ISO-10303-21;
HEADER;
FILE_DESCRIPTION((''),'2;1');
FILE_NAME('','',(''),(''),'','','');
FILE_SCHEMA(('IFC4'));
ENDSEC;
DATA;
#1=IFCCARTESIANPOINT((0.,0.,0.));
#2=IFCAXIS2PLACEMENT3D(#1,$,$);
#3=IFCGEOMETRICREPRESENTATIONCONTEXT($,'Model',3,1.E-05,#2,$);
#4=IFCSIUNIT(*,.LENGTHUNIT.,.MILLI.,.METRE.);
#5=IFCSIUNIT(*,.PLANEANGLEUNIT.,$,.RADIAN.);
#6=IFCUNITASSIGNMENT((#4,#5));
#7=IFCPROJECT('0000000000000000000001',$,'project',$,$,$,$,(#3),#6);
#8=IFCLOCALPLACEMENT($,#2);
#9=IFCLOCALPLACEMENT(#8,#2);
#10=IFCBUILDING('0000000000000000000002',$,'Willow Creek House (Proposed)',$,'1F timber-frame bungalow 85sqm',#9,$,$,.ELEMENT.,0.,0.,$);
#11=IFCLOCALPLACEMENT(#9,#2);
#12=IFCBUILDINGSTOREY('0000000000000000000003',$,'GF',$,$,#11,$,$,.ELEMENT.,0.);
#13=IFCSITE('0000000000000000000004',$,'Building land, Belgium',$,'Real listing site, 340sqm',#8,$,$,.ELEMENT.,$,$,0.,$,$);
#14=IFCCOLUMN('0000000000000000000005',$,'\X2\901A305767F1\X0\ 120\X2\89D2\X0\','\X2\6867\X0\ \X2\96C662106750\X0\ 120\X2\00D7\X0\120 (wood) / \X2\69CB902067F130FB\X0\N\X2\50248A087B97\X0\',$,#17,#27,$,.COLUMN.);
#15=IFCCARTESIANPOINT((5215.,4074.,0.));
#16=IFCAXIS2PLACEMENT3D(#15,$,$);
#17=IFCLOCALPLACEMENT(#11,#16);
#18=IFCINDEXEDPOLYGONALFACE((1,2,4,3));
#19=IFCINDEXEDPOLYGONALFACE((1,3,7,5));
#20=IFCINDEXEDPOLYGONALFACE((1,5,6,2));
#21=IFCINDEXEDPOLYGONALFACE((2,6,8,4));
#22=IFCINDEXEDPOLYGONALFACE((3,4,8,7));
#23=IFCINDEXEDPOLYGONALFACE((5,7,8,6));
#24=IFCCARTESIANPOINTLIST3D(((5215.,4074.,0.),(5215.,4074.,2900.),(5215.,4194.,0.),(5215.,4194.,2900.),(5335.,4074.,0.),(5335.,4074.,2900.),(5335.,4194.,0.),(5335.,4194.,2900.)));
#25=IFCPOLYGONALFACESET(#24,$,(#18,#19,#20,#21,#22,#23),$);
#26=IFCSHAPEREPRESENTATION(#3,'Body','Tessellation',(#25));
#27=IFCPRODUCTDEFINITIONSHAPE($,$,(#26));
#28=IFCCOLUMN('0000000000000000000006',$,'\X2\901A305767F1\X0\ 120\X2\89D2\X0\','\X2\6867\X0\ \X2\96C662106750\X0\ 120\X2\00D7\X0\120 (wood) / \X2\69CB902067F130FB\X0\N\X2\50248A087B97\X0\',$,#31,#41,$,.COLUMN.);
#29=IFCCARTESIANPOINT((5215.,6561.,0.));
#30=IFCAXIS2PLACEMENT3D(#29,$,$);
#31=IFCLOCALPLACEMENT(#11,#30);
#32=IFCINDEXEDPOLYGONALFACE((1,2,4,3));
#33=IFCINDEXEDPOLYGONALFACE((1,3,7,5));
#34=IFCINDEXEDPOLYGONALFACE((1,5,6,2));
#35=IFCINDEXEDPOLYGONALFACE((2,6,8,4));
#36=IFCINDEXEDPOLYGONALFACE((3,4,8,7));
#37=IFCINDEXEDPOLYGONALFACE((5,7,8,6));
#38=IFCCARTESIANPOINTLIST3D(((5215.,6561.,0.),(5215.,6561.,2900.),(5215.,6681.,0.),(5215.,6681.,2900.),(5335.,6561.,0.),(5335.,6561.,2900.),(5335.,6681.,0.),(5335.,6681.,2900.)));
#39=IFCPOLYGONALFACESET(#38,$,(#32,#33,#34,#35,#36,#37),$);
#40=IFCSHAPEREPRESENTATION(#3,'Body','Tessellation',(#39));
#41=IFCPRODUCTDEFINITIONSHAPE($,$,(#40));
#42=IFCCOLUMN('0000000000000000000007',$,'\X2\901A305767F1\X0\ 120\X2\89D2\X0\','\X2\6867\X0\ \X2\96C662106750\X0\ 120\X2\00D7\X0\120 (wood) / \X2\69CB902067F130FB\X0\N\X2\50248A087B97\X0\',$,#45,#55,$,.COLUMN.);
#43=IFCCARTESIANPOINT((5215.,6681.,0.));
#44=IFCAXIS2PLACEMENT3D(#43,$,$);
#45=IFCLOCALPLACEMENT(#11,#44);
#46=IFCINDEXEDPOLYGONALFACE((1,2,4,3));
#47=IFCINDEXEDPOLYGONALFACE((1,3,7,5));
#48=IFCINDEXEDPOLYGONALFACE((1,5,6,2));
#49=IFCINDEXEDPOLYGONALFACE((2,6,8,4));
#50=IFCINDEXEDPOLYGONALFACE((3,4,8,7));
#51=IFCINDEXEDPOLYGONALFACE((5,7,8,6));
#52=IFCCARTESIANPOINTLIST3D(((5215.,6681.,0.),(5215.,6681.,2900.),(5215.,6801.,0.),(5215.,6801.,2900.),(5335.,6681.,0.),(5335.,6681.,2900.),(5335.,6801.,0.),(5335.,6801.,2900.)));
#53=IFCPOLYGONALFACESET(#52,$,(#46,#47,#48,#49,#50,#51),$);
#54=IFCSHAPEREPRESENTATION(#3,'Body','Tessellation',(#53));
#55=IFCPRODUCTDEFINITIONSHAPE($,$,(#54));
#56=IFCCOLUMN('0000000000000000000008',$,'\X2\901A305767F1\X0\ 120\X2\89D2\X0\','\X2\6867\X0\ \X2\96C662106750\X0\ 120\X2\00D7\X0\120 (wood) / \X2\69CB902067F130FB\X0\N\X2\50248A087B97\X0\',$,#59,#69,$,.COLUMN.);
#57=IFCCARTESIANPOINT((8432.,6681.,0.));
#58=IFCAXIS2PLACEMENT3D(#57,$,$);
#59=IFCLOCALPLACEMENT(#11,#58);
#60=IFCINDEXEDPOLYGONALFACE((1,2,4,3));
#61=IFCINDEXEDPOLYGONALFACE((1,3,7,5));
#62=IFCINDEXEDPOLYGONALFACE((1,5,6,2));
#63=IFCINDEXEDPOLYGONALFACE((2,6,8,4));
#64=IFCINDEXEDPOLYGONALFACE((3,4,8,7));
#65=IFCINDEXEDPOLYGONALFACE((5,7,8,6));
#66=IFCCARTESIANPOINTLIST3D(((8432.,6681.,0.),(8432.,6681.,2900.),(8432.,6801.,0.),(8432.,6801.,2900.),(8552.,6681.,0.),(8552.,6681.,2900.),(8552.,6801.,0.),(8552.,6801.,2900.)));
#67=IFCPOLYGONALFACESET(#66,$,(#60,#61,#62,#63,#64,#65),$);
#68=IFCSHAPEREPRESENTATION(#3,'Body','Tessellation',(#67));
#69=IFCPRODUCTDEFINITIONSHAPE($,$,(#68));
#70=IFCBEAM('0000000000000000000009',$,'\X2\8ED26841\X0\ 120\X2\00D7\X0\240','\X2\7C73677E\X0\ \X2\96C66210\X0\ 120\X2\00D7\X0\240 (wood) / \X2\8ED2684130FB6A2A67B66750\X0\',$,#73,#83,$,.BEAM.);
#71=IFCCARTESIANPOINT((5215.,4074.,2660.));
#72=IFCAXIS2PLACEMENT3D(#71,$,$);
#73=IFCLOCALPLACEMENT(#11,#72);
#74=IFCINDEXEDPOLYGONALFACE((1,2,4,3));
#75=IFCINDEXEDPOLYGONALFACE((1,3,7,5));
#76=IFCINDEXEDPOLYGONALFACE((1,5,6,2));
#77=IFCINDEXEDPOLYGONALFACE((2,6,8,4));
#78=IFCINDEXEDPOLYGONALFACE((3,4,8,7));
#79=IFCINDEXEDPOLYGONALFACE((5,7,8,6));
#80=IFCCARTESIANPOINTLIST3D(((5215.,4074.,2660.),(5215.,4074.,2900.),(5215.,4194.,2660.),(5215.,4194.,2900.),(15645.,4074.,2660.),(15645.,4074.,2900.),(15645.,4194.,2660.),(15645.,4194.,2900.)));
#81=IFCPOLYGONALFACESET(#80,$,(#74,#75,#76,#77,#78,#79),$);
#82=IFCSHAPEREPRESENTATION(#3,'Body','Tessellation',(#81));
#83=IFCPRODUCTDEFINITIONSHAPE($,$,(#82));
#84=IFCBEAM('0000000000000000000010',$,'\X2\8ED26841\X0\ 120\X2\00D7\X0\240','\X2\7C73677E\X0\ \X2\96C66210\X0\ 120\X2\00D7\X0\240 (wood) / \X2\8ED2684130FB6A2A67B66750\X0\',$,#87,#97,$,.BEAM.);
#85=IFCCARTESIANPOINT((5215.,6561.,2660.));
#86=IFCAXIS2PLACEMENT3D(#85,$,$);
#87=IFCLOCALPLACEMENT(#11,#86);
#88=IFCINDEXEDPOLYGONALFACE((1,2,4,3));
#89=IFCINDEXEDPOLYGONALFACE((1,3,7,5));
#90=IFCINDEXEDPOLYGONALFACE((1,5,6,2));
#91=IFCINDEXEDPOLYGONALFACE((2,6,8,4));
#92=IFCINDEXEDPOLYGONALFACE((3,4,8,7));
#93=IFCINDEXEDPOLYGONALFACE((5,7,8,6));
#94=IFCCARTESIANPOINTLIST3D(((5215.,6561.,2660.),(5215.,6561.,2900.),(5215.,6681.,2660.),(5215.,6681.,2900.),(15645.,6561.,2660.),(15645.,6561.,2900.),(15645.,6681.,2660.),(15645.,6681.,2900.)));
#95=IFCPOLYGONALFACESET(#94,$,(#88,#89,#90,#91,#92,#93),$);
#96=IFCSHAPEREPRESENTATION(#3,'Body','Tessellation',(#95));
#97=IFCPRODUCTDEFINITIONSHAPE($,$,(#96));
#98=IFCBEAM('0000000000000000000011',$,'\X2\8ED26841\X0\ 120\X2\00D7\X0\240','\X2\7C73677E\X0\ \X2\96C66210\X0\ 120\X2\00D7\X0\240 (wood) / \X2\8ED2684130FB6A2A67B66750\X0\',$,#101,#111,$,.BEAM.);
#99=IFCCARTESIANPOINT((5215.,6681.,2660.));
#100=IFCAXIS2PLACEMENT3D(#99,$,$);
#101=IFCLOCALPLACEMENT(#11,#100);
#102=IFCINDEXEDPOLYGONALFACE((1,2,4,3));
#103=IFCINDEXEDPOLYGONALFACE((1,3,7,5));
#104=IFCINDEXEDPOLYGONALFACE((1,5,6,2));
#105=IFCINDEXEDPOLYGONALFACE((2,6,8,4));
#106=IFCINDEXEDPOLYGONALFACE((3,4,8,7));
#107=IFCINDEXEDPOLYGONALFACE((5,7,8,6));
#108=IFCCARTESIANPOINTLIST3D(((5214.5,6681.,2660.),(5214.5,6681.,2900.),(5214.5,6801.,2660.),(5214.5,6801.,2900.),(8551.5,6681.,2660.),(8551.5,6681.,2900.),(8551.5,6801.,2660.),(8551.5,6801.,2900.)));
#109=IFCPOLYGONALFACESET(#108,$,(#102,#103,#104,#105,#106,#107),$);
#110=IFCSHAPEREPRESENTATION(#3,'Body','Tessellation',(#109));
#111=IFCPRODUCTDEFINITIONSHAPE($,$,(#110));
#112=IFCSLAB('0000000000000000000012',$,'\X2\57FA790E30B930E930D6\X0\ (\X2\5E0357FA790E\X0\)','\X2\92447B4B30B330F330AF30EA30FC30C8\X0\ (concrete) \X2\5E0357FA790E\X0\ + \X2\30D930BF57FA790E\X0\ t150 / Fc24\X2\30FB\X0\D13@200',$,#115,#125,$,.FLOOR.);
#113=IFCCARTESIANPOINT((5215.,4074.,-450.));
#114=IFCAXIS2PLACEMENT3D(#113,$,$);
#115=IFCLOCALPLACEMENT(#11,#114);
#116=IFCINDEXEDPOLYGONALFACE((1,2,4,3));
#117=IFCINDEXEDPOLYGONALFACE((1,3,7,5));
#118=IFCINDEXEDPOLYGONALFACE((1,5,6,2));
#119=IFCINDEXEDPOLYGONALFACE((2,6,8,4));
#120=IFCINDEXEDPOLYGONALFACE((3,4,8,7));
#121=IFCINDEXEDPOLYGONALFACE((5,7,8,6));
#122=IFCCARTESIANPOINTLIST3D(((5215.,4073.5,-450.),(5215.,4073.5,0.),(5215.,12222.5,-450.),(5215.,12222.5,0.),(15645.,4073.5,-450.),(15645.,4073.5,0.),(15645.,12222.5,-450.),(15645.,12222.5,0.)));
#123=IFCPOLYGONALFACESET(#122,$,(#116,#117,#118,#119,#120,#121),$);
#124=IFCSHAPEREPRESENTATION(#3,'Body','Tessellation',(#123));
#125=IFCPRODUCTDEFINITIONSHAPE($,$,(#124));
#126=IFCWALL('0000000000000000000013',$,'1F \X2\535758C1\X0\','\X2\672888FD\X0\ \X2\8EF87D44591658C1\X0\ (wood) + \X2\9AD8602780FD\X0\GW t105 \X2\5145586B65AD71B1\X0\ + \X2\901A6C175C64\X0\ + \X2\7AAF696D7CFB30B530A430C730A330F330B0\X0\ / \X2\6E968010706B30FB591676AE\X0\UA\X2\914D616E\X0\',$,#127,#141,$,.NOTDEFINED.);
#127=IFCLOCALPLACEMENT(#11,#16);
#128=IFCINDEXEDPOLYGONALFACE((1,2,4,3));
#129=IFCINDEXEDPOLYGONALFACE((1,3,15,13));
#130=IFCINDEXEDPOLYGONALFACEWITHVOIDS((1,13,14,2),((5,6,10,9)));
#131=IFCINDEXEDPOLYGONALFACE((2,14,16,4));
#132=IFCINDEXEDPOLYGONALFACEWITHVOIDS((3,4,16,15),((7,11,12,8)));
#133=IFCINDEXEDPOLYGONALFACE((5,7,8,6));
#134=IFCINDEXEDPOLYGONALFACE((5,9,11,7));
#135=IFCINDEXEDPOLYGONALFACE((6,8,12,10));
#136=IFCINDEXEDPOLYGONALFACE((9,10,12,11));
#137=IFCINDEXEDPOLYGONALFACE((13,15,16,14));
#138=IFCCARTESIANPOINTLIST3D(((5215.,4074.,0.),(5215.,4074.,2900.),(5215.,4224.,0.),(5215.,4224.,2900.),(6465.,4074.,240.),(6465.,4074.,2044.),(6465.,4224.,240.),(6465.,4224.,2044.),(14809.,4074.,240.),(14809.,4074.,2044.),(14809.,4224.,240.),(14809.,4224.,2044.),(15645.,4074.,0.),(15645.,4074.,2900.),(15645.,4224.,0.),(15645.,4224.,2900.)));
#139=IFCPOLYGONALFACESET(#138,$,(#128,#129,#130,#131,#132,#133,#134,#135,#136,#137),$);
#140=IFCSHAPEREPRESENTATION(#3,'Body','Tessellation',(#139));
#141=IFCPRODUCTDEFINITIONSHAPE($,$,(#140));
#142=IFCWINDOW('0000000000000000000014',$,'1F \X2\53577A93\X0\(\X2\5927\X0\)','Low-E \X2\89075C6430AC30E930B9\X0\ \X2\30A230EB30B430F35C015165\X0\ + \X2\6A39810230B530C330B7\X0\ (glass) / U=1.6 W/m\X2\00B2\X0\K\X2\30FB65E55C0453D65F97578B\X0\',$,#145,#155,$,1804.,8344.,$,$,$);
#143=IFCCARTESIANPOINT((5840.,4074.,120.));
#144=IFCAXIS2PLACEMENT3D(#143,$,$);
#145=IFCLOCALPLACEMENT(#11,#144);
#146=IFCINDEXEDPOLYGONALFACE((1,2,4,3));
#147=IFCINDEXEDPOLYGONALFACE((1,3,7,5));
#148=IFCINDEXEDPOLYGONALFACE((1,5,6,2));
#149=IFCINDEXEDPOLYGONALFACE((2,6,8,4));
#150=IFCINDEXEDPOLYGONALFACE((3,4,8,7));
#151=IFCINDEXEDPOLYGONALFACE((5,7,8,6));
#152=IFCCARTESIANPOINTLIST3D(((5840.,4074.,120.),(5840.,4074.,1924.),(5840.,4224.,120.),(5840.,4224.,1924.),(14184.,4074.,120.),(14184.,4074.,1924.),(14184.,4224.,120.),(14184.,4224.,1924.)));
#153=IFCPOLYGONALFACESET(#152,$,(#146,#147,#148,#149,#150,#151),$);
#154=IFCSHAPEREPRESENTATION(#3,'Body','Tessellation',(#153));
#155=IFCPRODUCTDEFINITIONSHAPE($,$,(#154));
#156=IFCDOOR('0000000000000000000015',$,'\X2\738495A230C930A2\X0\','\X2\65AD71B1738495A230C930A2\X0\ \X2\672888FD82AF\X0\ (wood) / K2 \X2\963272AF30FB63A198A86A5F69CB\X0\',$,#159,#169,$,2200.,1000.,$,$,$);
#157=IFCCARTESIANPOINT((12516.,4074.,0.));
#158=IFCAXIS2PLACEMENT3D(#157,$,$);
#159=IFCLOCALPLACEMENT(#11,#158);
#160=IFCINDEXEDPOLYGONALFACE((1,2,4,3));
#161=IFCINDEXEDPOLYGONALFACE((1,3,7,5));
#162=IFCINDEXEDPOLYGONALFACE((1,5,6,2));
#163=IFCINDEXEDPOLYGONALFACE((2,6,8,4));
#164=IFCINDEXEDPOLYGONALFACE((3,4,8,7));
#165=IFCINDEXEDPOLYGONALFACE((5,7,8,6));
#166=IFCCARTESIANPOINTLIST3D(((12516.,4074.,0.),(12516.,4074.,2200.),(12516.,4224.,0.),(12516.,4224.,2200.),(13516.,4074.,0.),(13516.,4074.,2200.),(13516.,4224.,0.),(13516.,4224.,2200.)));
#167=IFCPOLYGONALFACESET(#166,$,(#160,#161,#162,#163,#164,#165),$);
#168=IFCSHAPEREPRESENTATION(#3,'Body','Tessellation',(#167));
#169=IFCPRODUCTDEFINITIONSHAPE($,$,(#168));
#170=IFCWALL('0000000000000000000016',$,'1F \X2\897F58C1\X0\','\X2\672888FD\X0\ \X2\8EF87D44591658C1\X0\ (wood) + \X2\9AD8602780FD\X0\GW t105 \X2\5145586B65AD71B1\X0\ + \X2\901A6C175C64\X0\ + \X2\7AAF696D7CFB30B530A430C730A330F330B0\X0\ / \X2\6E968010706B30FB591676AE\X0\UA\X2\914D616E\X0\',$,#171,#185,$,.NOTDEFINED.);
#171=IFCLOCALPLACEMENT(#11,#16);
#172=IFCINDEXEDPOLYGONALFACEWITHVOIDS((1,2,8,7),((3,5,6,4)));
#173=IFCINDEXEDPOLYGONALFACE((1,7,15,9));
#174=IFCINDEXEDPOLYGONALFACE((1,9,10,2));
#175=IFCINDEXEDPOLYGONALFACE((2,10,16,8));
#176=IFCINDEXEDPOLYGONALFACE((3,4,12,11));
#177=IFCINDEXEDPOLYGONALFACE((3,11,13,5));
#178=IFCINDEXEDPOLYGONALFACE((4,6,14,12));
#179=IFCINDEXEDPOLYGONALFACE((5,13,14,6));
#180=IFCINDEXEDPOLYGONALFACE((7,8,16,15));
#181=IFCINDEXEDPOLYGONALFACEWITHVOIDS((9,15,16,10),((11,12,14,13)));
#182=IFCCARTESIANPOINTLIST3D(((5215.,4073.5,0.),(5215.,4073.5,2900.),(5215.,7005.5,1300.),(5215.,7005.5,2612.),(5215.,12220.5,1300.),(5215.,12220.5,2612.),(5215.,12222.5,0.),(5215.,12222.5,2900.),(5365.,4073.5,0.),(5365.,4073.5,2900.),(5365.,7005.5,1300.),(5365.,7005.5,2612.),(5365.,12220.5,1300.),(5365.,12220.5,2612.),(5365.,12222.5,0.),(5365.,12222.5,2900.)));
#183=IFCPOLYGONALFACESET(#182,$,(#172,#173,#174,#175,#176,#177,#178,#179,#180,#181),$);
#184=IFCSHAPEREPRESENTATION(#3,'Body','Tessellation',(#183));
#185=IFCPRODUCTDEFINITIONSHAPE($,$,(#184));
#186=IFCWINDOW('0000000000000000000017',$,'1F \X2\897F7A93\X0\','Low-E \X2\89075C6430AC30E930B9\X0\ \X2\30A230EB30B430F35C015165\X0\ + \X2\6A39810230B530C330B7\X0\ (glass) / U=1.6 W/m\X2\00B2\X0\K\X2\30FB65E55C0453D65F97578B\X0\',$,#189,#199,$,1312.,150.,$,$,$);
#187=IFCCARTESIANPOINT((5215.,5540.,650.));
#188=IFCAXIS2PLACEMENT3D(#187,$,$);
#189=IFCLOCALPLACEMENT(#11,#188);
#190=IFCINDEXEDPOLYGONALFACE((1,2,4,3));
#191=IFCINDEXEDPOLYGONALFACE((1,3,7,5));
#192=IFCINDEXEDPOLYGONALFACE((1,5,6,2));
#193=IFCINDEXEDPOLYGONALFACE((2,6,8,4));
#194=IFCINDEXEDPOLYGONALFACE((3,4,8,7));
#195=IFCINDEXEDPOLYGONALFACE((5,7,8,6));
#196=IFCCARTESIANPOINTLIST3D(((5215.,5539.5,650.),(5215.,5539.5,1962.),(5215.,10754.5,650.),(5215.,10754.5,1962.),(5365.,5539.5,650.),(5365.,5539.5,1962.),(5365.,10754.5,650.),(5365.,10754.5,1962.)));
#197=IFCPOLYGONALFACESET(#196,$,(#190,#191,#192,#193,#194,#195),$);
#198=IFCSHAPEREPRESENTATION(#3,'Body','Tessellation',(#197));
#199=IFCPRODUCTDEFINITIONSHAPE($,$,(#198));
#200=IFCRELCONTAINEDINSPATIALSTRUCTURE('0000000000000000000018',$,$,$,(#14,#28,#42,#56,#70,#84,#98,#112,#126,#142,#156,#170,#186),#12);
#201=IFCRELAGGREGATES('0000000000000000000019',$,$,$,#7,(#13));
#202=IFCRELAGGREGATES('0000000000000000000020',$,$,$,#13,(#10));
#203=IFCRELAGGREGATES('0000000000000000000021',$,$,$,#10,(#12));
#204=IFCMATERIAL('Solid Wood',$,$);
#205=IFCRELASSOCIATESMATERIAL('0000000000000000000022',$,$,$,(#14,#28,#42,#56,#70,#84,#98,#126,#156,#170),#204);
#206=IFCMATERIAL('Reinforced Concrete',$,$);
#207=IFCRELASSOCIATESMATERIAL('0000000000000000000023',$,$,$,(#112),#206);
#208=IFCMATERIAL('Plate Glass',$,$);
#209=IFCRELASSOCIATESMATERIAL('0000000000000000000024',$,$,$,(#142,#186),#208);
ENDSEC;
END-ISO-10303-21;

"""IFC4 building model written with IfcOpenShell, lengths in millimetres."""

from ifc_helpers import new_model, si_unit, frame, frame_2d, origin, place, context, project, spatial, rectangle, extrude, material, element, fill, save


model = new_model("IFC4")

# Units and contexts
model_context = context("Model", 3, precision=1e-05, world=origin())
ifc_project = project(units=[si_unit("LENGTHUNIT", "METRE", prefix="MILLI"), si_unit("PLANEANGLEUNIT", "RADIAN")], contexts=[model_context])

# Site, building, storey
site_placement = place(None, origin())
site = spatial("IfcSite", under=ifc_project, at=site_placement, Name="Building land, Belgium", ObjectType="Real listing site, 340sqm", CompositionType="ELEMENT", RefElevation=0.0)
building_placement = place(site_placement, origin())
building = spatial("IfcBuilding", under=site, at=building_placement, Name="Willow Creek House (Proposed)", ObjectType="1F timber-frame bungalow 85sqm", CompositionType="ELEMENT", ElevationOfRefHeight=0.0, ElevationOfTerrain=0.0)
storey_placement = place(building_placement, origin())
storey = spatial("IfcBuildingStorey", under=building, at=storey_placement, Name="GF", CompositionType="ELEMENT", Elevation=0.0)

# Columns
ifc_material_1 = material(Name="Solid Wood")
column_1_placement = place(storey_placement, frame((5215.0, 4074.0, 0.0)))
element("IfcColumn", 1, at=column_1_placement, inside=storey, material=ifc_material_1, Name="通し柱 120角", Description="桧 集成材 120×120 (wood) / 構造柱・N値計算", PredefinedType="COLUMN", context=model_context, shape_type="SweptSolid", body=[
    extrude(rectangle(XDim=120.0, YDim=120.0, at=frame_2d((60.0, 60.0))), frame((5215.0, 4074.0, 0.0)), (0.0, 0.0, 1.0), 2900.0),
])
column_2_placement = place(storey_placement, frame((5215.0, 6561.0, 0.0)))
element("IfcColumn", 2, at=column_2_placement, inside=storey, material=ifc_material_1, Name="通し柱 120角", Description="桧 集成材 120×120 (wood) / 構造柱・N値計算", PredefinedType="COLUMN", context=model_context, shape_type="SweptSolid", body=[
    extrude(rectangle(XDim=120.0, YDim=120.0, at=frame_2d((60.0, 60.0))), frame((5215.0, 6561.0, 0.0)), (0.0, 0.0, 1.0), 2900.0),
])
column_3_placement = place(storey_placement, frame((5215.0, 6681.0, 0.0)))
element("IfcColumn", 3, at=column_3_placement, inside=storey, material=ifc_material_1, Name="通し柱 120角", Description="桧 集成材 120×120 (wood) / 構造柱・N値計算", PredefinedType="COLUMN", context=model_context, shape_type="SweptSolid", body=[
    extrude(rectangle(XDim=120.0, YDim=120.0, at=frame_2d((60.0, 60.0))), frame((5215.0, 6681.0, 0.0)), (0.0, 0.0, 1.0), 2900.0),
])
column_4_placement = place(storey_placement, frame((8432.0, 6681.0, 0.0)))
element("IfcColumn", 4, at=column_4_placement, inside=storey, material=ifc_material_1, Name="通し柱 120角", Description="桧 集成材 120×120 (wood) / 構造柱・N値計算", PredefinedType="COLUMN", context=model_context, shape_type="SweptSolid", body=[
    extrude(rectangle(XDim=120.0, YDim=120.0, at=frame_2d((60.0, 60.0))), frame((8432.0, 6681.0, 0.0)), (0.0, 0.0, 1.0), 2900.0),
])

# Beams
beam_1_placement = place(storey_placement, frame((5215.0, 4074.0, 2660.0)))
element("IfcBeam", 5, at=beam_1_placement, inside=storey, material=ifc_material_1, Name="軒桁 120×240", Description="米松 集成 120×240 (wood) / 軒桁・横架材", PredefinedType="BEAM", context=model_context, shape_type="SweptSolid", body=[
    extrude(rectangle(XDim=10430.0, YDim=120.0, at=frame_2d((5215.0, 60.0))), frame((5215.0, 4074.0, 2660.0)), (0.0, 0.0, 1.0), 240.0),
])
beam_2_placement = place(storey_placement, frame((5215.0, 6561.0, 2660.0)))
element("IfcBeam", 6, at=beam_2_placement, inside=storey, material=ifc_material_1, Name="軒桁 120×240", Description="米松 集成 120×240 (wood) / 軒桁・横架材", PredefinedType="BEAM", context=model_context, shape_type="SweptSolid", body=[
    extrude(rectangle(XDim=10430.0, YDim=120.0, at=frame_2d((5215.0, 60.0))), frame((5215.0, 6561.0, 2660.0)), (0.0, 0.0, 1.0), 240.0),
])
beam_3_placement = place(storey_placement, frame((5215.0, 6681.0, 2660.0)))
element("IfcBeam", 7, at=beam_3_placement, inside=storey, material=ifc_material_1, Name="軒桁 120×240", Description="米松 集成 120×240 (wood) / 軒桁・横架材", PredefinedType="BEAM", context=model_context, shape_type="SweptSolid", body=[
    extrude(rectangle(XDim=3337.0, YDim=120.0, at=frame_2d((1668.0, 60.0))), frame((5215.0, 6681.0, 2660.0)), (0.0, 0.0, 1.0), 240.0),
])

# Slab
ifc_material_2 = material(Name="Reinforced Concrete")
slab_1_placement = place(storey_placement, frame((5215.0, 4074.0, -450.0)))
element("IfcSlab", 8, at=slab_1_placement, inside=storey, material=ifc_material_2, Name="基礎スラブ (布基礎)", Description="鉄筋コンクリート (concrete) 布基礎 + ベタ基礎 t150 / Fc24・D13@200", PredefinedType="FLOOR", context=model_context, shape_type="SweptSolid", body=[
    extrude(rectangle(XDim=10430.0, YDim=8149.0, at=frame_2d((5215.0, 4074.0))), frame((5215.0, 4074.0, -450.0)), (0.0, 0.0, 1.0), 450.0),
])

# Wall, openings, window, door
wall_1_placement = place(storey_placement, frame((5215.0, 4074.0, 0.0)))
wall_1 = element("IfcWall", 9, at=wall_1_placement, inside=storey, material=ifc_material_1, Name="1F 南壁", Description="木製 軸組外壁 (wood) + 高性能GW t105 充填断熱 + 通気層 + 窯業系サイディング / 準耐火・外皮UA配慮", PredefinedType="NOTDEFINED", context=model_context, shape_type="SweptSolid", body=[
    extrude(rectangle(XDim=10430.0, YDim=150.0, at=frame_2d((5215.0, 75.0))), frame((5215.0, 4074.0, 0.0)), (0.0, 0.0, 1.0), 2900.0),
])
opening_1_placement = place(storey_placement, frame((5840.0, 4074.0, 120.0)))
opening_1 = element("IfcOpeningElement", 10, at=opening_1_placement, cuts=wall_1, PredefinedType="NOTDEFINED", context=model_context, shape_type="SweptSolid", body=[
    extrude(rectangle(XDim=8344.0, YDim=150.0, at=frame_2d((4172.0, 75.0))), frame((5840.0, 4074.0, 120.0)), (0.0, 0.0, 1.0), 1804.0),
])
opening_2_placement = place(storey_placement, frame((12516.0, 4074.0, 0.0)))
opening_2 = element("IfcOpeningElement", 11, at=opening_2_placement, cuts=wall_1, PredefinedType="NOTDEFINED", context=model_context, shape_type="SweptSolid", body=[
    extrude(rectangle(XDim=1000.0, YDim=150.0, at=frame_2d((500.0, 75.0))), frame((12516.0, 4074.0, 0.0)), (0.0, 0.0, 1.0), 2200.0),
])
ifc_material_3 = material(Name="Plate Glass")
window_1_placement = place(storey_placement, frame((5840.0, 4074.0, 120.0)))
window_1 = element("IfcWindow", 12, at=window_1_placement, inside=storey, material=ifc_material_3, Name="1F 南窓(大)", Description="Low-E 複層ガラス アルゴン封入 + 樹脂サッシ (glass) / U=1.6 W/m²K・日射取得型", OverallHeight=1804.0, OverallWidth=8344.0, context=model_context, shape_type="SweptSolid", body=[
    extrude(rectangle(XDim=8344.0, YDim=150.0, at=frame_2d((4172.0, 75.0))), frame((5840.0, 4074.0, 120.0)), (0.0, 0.0, 1.0), 1804.0),
])
fill(opening_1, window_1)
door_placement = place(storey_placement, frame((12516.0, 4074.0, 0.0)))
door = element("IfcDoor", 13, at=door_placement, inside=storey, material=ifc_material_1, Name="玄関ドア", Description="断熱玄関ドア 木製芯 (wood) / K2 防犯・採風機構", OverallHeight=2200.0, OverallWidth=1000.0, context=model_context, shape_type="SweptSolid", body=[
    extrude(rectangle(XDim=1000.0, YDim=150.0, at=frame_2d((500.0, 75.0))), frame((12516.0, 4074.0, 0.0)), (0.0, 0.0, 1.0), 2200.0),
])
fill(opening_2, door)

# Wall, opening, window
wall_2_placement = place(storey_placement, frame((5215.0, 4074.0, 0.0)))
wall_2 = element("IfcWall", 14, at=wall_2_placement, inside=storey, material=ifc_material_1, Name="1F 西壁", Description="木製 軸組外壁 (wood) + 高性能GW t105 充填断熱 + 通気層 + 窯業系サイディング / 準耐火・外皮UA配慮", PredefinedType="NOTDEFINED", context=model_context, shape_type="SweptSolid", body=[
    extrude(rectangle(XDim=150.0, YDim=8149.0, at=frame_2d((75.0, 4074.0))), frame((5215.0, 4074.0, 0.0)), (0.0, 0.0, 1.0), 2900.0),
])
opening_3_placement = place(storey_placement, frame((5215.0, 5540.0, 650.0)))
opening_3 = element("IfcOpeningElement", 15, at=opening_3_placement, cuts=wall_2, PredefinedType="NOTDEFINED", context=model_context, shape_type="SweptSolid", body=[
    extrude(rectangle(XDim=150.0, YDim=5215.0, at=frame_2d((75.0, 2607.0))), frame((5215.0, 5540.0, 650.0)), (0.0, 0.0, 1.0), 1312.0),
])
window_2_placement = place(storey_placement, frame((5215.0, 5540.0, 650.0)))
window_2 = element("IfcWindow", 16, at=window_2_placement, inside=storey, material=ifc_material_3, Name="1F 西窓", Description="Low-E 複層ガラス アルゴン封入 + 樹脂サッシ (glass) / U=1.6 W/m²K・日射取得型", OverallHeight=1312.0, OverallWidth=150.0, context=model_context, shape_type="SweptSolid", body=[
    extrude(rectangle(XDim=150.0, YDim=5215.0, at=frame_2d((75.0, 2607.0))), frame((5215.0, 5540.0, 650.0)), (0.0, 0.0, 1.0), 1312.0),
])
fill(opening_3, window_2)

save(model, "model.ifc")
